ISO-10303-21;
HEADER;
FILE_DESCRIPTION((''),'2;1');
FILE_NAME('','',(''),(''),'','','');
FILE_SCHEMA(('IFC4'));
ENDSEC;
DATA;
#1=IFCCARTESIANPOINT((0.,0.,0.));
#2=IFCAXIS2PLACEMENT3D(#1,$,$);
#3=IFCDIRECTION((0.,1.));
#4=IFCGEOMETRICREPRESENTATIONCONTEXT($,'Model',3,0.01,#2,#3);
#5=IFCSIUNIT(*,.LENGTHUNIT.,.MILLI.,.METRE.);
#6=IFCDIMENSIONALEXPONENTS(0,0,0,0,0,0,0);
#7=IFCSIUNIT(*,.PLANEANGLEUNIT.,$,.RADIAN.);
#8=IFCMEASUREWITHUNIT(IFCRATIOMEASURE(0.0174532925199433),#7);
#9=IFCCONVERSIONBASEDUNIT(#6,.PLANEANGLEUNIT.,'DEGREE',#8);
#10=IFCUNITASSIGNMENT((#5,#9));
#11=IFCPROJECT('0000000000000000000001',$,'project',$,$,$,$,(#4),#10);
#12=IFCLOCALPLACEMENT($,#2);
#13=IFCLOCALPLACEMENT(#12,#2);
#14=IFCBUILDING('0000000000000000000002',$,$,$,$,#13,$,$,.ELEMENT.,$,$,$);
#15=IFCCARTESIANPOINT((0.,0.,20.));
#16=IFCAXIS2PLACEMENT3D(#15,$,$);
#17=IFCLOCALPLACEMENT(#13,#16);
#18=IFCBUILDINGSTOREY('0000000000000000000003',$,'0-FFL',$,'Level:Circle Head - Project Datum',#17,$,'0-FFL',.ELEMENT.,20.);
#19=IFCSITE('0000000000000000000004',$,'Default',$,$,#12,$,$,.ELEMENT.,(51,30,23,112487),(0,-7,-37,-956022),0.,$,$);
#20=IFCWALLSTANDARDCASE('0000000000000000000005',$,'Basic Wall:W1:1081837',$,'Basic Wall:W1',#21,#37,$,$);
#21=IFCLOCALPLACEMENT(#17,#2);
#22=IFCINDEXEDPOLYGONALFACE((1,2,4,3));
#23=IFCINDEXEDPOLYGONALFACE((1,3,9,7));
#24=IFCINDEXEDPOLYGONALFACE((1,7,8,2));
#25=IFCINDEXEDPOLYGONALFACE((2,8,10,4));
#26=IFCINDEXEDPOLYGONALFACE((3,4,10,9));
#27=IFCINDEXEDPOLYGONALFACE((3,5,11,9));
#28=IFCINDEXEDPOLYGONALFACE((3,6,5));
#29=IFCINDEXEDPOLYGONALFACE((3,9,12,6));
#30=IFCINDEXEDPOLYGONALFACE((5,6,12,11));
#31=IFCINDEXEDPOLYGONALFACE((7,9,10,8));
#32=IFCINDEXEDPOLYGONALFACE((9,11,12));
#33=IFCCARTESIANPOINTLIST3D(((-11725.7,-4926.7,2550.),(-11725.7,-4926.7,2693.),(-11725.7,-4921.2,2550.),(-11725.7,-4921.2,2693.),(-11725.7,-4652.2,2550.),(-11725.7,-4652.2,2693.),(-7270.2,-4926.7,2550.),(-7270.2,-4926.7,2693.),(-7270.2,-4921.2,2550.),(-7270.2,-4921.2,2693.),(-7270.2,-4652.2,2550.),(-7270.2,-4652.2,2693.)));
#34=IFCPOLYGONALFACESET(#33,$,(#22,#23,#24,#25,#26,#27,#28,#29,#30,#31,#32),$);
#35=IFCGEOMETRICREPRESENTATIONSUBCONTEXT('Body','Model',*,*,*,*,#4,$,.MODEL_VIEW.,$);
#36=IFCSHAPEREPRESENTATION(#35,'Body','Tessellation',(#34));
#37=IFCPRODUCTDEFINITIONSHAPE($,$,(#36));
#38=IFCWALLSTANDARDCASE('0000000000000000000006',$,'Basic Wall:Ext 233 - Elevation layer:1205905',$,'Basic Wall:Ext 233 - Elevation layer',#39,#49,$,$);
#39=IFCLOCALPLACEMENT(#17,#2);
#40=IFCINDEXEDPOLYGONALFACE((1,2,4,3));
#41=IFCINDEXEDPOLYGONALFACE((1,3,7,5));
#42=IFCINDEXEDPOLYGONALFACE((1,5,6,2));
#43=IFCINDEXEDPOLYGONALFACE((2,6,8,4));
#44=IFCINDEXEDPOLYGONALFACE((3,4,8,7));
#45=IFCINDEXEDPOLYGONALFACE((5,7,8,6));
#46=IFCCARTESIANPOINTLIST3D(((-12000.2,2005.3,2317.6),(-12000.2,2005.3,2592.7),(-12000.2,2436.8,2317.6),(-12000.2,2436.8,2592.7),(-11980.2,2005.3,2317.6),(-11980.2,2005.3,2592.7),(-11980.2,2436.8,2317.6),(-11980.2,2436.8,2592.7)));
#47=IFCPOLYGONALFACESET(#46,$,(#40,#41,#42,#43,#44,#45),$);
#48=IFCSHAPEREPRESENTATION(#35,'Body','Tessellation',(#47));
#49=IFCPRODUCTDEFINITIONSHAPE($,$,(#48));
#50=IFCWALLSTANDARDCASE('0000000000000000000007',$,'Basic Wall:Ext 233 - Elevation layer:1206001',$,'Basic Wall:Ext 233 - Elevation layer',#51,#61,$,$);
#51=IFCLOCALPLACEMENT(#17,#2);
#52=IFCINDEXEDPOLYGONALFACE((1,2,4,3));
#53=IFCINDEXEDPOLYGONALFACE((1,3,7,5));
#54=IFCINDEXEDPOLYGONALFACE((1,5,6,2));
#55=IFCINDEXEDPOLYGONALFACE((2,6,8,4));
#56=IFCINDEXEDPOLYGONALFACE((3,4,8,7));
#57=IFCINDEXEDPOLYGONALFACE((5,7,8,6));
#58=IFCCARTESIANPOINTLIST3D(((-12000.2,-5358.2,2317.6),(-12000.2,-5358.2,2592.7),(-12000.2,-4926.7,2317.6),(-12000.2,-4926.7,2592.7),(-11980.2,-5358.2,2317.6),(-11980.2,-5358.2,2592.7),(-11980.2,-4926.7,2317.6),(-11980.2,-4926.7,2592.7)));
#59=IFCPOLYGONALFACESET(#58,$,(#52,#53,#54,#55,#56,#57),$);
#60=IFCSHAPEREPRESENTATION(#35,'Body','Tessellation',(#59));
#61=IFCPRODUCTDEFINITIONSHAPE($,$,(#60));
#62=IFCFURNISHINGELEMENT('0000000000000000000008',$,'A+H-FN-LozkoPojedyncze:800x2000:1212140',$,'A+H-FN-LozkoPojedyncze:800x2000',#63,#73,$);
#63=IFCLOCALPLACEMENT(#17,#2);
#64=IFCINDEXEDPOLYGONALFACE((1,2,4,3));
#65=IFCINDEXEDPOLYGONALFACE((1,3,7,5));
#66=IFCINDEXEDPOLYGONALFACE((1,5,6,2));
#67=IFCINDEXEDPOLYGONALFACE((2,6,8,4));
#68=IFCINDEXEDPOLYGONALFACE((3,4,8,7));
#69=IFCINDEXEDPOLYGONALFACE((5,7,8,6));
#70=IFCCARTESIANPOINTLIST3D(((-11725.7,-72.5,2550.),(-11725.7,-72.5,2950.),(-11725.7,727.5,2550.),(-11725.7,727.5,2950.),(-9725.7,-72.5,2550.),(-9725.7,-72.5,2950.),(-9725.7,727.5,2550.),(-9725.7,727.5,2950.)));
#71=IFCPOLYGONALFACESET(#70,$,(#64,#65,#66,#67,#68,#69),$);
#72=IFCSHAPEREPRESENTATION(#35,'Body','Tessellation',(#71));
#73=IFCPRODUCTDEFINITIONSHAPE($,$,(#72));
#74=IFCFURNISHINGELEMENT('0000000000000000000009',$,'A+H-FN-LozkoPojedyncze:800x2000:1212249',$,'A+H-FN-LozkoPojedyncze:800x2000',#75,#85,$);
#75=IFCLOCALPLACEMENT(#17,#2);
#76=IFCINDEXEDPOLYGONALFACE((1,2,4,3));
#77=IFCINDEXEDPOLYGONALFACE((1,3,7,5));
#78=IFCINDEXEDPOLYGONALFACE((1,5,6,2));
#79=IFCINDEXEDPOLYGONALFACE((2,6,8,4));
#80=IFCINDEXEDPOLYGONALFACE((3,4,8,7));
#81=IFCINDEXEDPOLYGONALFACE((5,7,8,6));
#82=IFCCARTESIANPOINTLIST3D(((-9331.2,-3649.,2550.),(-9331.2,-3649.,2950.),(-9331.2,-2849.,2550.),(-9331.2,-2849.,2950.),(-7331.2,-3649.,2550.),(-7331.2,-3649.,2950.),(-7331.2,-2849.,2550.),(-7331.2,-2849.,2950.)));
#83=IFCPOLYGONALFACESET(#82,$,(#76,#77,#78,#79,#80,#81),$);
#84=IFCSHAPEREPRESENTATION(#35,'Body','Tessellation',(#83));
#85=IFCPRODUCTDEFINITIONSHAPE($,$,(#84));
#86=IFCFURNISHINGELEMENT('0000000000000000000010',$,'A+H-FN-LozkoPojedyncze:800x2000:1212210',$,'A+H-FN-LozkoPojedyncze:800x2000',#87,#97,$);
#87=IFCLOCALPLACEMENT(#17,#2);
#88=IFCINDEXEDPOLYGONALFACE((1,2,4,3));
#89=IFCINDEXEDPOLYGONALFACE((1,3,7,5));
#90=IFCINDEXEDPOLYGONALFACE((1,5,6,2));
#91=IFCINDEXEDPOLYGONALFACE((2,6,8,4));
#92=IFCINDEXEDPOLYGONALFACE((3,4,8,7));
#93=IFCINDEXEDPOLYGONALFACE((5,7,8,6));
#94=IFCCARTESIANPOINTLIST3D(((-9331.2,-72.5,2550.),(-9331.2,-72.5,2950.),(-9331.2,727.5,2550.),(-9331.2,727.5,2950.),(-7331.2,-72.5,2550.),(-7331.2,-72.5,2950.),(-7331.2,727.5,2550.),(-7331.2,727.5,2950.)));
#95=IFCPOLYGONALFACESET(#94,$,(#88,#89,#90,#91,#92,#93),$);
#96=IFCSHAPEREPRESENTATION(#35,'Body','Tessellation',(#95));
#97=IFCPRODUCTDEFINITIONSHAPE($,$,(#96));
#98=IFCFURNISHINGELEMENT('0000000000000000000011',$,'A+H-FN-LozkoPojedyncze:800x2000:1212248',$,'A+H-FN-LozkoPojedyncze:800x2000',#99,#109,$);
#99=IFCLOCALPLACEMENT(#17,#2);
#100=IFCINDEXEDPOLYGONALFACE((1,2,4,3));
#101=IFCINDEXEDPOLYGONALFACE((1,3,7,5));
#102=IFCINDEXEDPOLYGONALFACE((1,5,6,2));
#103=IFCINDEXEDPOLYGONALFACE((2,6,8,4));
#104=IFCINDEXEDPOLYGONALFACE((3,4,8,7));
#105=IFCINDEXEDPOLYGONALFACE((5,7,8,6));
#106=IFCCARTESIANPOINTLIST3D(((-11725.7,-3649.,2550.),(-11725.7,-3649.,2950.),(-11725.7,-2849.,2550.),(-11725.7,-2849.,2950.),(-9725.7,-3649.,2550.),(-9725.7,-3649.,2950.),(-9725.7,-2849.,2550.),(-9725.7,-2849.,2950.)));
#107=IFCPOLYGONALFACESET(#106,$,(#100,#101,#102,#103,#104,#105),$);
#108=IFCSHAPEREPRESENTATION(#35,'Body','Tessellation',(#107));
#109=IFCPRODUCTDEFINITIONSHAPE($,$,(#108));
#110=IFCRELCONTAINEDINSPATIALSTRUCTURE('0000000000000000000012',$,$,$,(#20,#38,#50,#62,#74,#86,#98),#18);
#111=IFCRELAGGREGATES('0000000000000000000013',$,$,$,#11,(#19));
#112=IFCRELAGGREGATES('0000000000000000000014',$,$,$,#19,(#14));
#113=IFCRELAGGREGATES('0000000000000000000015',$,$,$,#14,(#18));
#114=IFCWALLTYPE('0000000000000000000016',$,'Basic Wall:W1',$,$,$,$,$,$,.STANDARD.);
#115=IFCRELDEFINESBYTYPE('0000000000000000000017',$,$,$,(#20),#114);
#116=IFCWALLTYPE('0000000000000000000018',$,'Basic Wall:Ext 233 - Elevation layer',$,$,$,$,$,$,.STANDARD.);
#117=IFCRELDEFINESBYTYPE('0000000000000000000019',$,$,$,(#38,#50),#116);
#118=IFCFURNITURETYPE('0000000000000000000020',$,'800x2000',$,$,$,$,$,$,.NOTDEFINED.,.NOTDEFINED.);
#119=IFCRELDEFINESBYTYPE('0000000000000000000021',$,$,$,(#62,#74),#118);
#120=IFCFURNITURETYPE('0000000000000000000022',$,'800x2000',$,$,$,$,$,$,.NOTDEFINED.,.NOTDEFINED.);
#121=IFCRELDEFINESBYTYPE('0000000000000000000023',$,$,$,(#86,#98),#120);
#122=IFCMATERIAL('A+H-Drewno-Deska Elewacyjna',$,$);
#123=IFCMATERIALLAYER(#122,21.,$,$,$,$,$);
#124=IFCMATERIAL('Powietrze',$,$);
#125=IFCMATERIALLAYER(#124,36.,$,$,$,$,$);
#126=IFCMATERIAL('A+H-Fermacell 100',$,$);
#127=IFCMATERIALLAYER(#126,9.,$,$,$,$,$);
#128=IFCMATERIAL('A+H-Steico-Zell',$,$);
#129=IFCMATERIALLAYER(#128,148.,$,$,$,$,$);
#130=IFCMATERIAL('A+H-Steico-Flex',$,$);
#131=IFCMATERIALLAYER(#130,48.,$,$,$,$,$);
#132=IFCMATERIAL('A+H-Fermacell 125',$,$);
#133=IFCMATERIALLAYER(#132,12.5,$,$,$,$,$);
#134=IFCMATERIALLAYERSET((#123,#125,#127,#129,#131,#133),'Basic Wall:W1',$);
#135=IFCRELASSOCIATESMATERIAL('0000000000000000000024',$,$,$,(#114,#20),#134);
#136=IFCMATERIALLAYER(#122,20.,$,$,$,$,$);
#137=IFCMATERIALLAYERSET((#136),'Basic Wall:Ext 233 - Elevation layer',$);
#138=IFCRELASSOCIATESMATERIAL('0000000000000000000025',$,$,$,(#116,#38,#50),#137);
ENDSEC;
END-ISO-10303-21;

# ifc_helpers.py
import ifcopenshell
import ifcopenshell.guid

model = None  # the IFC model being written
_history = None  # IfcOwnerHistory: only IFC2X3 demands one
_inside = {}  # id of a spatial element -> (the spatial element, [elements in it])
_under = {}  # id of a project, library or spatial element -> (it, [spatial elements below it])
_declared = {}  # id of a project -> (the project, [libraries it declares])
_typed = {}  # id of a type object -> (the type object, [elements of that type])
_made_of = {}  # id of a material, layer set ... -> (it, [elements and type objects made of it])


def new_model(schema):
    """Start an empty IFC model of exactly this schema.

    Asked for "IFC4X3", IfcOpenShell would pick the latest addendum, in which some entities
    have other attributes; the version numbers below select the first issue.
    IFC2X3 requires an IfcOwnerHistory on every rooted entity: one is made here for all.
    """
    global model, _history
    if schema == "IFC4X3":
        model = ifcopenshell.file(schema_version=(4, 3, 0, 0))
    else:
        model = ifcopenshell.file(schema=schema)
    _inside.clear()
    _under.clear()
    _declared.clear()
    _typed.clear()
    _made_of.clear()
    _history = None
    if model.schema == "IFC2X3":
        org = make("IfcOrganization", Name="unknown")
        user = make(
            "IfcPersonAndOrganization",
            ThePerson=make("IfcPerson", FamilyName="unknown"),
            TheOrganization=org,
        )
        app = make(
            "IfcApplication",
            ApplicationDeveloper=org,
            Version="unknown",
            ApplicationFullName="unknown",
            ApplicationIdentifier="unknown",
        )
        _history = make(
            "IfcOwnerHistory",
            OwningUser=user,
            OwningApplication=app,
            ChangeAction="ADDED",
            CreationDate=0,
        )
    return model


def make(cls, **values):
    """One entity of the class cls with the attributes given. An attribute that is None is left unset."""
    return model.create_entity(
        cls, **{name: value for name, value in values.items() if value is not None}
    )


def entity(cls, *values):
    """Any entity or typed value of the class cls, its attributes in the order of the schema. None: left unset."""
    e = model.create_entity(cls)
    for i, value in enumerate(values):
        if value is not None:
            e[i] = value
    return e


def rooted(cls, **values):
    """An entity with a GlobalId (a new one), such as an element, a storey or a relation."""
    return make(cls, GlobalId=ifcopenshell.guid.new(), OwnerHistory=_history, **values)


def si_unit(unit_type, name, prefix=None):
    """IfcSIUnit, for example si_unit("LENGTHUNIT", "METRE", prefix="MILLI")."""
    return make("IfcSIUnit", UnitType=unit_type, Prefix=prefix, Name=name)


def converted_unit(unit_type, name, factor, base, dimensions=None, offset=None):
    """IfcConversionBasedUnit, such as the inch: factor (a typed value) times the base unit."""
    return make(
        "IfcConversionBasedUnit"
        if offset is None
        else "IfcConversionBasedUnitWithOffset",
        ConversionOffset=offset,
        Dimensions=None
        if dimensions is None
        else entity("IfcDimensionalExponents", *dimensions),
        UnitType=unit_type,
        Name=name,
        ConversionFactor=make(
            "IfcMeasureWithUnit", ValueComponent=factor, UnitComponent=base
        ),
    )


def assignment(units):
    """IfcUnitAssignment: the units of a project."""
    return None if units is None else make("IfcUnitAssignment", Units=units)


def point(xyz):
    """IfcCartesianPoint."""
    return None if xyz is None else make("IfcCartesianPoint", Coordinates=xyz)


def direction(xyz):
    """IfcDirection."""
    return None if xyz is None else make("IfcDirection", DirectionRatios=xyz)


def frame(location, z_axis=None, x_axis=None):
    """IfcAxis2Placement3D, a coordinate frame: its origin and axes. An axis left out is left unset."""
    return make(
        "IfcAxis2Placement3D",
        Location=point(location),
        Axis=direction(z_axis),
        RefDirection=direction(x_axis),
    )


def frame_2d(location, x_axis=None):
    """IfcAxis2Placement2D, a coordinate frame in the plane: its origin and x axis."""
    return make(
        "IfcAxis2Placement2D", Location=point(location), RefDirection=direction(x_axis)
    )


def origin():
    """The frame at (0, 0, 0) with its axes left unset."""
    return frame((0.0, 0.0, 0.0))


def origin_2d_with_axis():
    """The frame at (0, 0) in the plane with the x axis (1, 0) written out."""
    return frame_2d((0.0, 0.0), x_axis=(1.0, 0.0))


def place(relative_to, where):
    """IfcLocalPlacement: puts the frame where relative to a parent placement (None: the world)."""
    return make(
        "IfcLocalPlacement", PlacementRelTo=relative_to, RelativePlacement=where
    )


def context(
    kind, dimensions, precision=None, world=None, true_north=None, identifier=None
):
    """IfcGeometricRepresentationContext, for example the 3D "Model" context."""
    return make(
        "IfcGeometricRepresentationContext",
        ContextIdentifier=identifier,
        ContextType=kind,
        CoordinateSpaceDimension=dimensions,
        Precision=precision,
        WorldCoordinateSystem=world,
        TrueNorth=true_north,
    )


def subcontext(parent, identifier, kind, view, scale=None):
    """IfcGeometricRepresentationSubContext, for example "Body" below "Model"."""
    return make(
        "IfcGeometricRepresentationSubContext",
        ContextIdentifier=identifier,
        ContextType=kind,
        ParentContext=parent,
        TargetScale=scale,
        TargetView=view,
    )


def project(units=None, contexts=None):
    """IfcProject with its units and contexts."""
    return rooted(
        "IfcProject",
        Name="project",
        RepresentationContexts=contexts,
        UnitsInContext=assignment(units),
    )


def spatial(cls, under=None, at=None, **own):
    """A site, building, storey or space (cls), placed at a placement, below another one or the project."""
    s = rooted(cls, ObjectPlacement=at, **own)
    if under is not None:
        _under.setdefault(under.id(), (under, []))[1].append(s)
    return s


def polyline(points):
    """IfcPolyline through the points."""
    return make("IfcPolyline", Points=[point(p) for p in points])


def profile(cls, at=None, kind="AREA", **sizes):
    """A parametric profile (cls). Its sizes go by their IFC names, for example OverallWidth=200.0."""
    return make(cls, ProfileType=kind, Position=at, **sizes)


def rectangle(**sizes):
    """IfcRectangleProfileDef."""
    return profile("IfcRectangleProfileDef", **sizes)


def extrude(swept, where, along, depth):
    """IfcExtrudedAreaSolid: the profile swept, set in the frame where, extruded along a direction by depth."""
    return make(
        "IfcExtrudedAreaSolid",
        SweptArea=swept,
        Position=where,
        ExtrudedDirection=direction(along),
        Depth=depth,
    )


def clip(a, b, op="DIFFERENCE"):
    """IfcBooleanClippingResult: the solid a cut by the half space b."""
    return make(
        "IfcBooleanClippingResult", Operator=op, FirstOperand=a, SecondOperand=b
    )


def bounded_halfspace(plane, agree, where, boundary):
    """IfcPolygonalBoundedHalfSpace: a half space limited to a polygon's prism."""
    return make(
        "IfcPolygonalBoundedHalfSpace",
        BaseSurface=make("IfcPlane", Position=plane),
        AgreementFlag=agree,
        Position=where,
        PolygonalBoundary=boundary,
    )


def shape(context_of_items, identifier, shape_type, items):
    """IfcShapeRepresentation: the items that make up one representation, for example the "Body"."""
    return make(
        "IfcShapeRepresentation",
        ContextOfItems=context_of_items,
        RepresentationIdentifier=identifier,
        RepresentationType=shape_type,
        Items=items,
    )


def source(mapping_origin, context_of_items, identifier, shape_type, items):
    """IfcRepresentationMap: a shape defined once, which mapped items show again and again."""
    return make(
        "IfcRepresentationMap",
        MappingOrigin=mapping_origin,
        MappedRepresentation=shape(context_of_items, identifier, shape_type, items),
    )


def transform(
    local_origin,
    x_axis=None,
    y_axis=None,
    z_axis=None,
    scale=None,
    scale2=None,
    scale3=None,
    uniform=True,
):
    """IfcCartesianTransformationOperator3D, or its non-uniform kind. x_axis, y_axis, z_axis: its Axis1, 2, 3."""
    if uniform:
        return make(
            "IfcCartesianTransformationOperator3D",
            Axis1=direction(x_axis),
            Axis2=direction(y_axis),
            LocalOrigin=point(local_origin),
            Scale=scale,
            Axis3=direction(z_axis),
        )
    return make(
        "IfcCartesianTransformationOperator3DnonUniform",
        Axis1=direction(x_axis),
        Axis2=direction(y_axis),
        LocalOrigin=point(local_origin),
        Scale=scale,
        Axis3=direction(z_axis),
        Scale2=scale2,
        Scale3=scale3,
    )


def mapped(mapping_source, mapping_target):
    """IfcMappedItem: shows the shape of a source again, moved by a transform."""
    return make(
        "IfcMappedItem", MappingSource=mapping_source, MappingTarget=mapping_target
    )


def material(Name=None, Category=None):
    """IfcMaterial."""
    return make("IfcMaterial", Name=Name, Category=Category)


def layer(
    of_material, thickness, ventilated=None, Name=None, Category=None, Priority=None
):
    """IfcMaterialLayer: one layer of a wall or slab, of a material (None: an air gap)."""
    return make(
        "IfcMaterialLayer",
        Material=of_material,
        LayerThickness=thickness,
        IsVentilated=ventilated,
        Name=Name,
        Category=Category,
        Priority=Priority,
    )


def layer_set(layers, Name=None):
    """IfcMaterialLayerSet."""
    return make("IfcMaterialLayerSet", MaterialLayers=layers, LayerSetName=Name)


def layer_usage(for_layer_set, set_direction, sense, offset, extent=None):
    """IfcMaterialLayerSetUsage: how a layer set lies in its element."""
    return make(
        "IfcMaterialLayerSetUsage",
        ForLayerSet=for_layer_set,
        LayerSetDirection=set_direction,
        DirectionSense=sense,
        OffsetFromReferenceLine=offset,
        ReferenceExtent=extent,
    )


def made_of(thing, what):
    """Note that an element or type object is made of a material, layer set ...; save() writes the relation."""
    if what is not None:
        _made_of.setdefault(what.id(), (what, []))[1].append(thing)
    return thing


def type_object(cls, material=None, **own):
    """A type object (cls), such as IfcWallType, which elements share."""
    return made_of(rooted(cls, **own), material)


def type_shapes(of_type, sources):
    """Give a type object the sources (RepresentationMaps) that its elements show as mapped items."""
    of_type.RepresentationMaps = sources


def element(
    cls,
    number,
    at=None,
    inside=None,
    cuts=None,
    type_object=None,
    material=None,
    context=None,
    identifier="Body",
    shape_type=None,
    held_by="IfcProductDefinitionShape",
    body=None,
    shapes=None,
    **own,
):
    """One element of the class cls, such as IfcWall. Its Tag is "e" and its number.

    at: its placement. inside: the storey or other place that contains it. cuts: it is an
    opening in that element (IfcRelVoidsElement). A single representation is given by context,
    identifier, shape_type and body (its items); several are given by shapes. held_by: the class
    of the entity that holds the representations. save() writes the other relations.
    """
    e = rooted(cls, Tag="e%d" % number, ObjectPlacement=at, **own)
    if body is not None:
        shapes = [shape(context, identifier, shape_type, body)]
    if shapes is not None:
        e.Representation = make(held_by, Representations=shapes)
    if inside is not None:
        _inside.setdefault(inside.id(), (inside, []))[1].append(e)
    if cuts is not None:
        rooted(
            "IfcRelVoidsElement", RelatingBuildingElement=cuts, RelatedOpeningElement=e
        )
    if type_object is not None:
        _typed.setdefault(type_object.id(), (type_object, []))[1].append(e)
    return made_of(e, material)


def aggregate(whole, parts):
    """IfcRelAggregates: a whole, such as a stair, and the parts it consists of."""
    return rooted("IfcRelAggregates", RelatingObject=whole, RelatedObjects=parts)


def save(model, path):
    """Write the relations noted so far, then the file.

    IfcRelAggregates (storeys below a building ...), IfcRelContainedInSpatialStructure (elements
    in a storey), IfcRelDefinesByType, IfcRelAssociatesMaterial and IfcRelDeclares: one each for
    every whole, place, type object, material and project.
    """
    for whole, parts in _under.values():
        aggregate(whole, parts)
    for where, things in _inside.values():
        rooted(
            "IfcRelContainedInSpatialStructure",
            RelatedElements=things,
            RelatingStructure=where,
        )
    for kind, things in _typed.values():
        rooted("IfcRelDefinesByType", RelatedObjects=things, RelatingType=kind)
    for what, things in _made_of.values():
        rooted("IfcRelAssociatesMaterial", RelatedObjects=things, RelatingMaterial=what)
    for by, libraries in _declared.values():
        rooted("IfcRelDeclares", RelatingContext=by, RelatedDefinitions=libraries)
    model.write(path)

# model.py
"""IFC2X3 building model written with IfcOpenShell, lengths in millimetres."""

from ifc_helpers import new_model, entity, si_unit, converted_unit, direction, frame, frame_2d, origin, origin_2d_with_axis, place, context, subcontext, project, spatial, polyline, rectangle, extrude, clip, bounded_halfspace, source, transform, mapped, material, layer, layer_set, layer_usage, type_object, type_shapes, element, save


model = new_model("IFC2X3")

# Units and contexts
model_context = context("Model", 3, precision=0.01, world=origin(), true_north=direction((0.0, 1.0)))
body_context = subcontext(model_context, "Body", "Model", "MODEL_VIEW")
ifc_project = project(units=[si_unit("LENGTHUNIT", "METRE", prefix="MILLI"), converted_unit("PLANEANGLEUNIT", "DEGREE", entity("IfcRatioMeasure", 0.0174532925199433), si_unit("PLANEANGLEUNIT", "RADIAN"), dimensions=[0, 0, 0, 0, 0, 0, 0])], contexts=[model_context])

# Site, building, storey
site_placement = place(None, origin())
site = spatial("IfcSite", under=ifc_project, at=site_placement, Name="Default", CompositionType="ELEMENT", RefLatitude=(51, 30, 23, 112487), RefLongitude=(0, -7, -37, -956022), RefElevation=0.0)
building_placement = place(site_placement, origin())
building = spatial("IfcBuilding", under=site, at=building_placement, CompositionType="ELEMENT")
storey_placement = place(building_placement, frame((0.0, 0.0, 20.0)))
storey = spatial("IfcBuildingStorey", under=building, at=storey_placement, Name="0-FFL", ObjectType="Level:Circle Head - Project Datum", LongName="0-FFL", CompositionType="ELEMENT", Elevation=20.0)

# Shared definitions
ifc_material_1 = material(Name="A+H-Steico-Zell")
ifc_material_2 = material(Name="A+H-Fermacell 100")

# Walls
ifc_material_3 = material(Name="A+H-Drewno-Deska Elewacyjna")
ifc_layer_1 = layer(ifc_material_3, 21.0)
ifc_material_4 = material(Name="Powietrze")
ifc_layer_2 = layer(ifc_material_4, 36.0)
ifc_layer_3 = layer(ifc_material_2, 9.0)
ifc_layer_4 = layer(ifc_material_1, 148.0)
ifc_material_5 = material(Name="A+H-Steico-Flex")
ifc_layer_5 = layer(ifc_material_5, 48.0)
ifc_material_6 = material(Name="A+H-Fermacell 125")
ifc_layer_6 = layer(ifc_material_6, 12.5)
ifc_layer_set_1 = layer_set([ifc_layer_1, ifc_layer_2, ifc_layer_3, ifc_layer_4, ifc_layer_5, ifc_layer_6], Name="Basic Wall:W1")
ifc_layer_usage_1 = layer_usage(ifc_layer_set_1, "AXIS2", "POSITIVE", -137.2)
wall_type_1 = type_object("IfcWallType", Name="Basic Wall:W1", PredefinedType="STANDARD", material=ifc_layer_set_1)
wall_1_placement = place(storey_placement, frame((-11725.7, -4789.5, 2550.0)))
element("IfcWallStandardCase", 1, at=wall_1_placement, inside=storey, type_object=wall_type_1, material=ifc_layer_usage_1, Name="Basic Wall:W1:1081837", ObjectType="Basic Wall:W1", context=body_context, shape_type="Clipping", body=[
    clip(extrude(rectangle(XDim=4455.5, YDim=274.5, at=frame_2d((2227.8, 0.0), x_axis=(-1.0, 0.0))), origin(), (0.0, 0.0, 1.0), 143.0), bounded_halfspace(frame((4455.5, 137.3, 143.0), z_axis=(0.0, -0.469472, 0.882948), x_axis=(1.0, 0.0, 0.0)), False, frame((4455.5, 137.3, 143.0)), polyline([(0.0, 0.0), (-61.0, 0.0), (-4455.5, 0.0), (-4455.5, -269.0), (0.0, -269.0), (0.0, 0.0)]))),
])
ifc_layer_7 = layer(ifc_material_3, 20.0)
ifc_layer_set_2 = layer_set([ifc_layer_7], Name="Basic Wall:Ext 233 - Elevation layer")
ifc_layer_usage_2 = layer_usage(ifc_layer_set_2, "AXIS2", "NEGATIVE", 10.0)
wall_type_2 = type_object("IfcWallType", Name="Basic Wall:Ext 233 - Elevation layer", PredefinedType="STANDARD", material=ifc_layer_set_2)
wall_2_placement = place(storey_placement, frame((-11990.2, 2005.3, 2317.6), z_axis=(0.0, 0.0, 1.0), x_axis=(0.0, 1.0, 0.0)))
element("IfcWallStandardCase", 2, at=wall_2_placement, inside=storey, type_object=wall_type_2, material=ifc_layer_usage_2, Name="Basic Wall:Ext 233 - Elevation layer:1205905", ObjectType="Basic Wall:Ext 233 - Elevation layer", context=body_context, shape_type="SweptSolid", body=[
    extrude(rectangle(XDim=431.5, YDim=20.0, at=frame_2d((215.7, 0.0), x_axis=(-1.0, 0.0))), origin(), (0.0, 0.0, 1.0), 275.1),
])
ifc_layer_usage_3 = layer_usage(ifc_layer_set_2, "AXIS2", "POSITIVE", -10.0)
wall_3_placement = place(storey_placement, frame((-11990.2, -4926.7, 2317.6), z_axis=(0.0, 0.0, 1.0), x_axis=(0.0, -1.0, 0.0)))
element("IfcWallStandardCase", 3, at=wall_3_placement, inside=storey, type_object=wall_type_2, material=ifc_layer_usage_3, Name="Basic Wall:Ext 233 - Elevation layer:1206001", ObjectType="Basic Wall:Ext 233 - Elevation layer", context=body_context, shape_type="SweptSolid", body=[
    extrude(rectangle(XDim=431.5, YDim=20.0, at=frame_2d((215.7, 0.0), x_axis=(-1.0, 0.0))), origin(), (0.0, 0.0, 1.0), 275.1),
])

# Furnishing elements
furniture_type_1 = type_object("IfcFurnitureType", Name="800x2000")
shared_shape_1 = source(origin(), body_context, "Body", "SweptSolid", [
    extrude(rectangle(XDim=800.0, YDim=2000.0, at=origin_2d_with_axis()), frame((0.0, 0.0, 0.0), z_axis=(0.0, 0.0, 1.0), x_axis=(-1.0, 0.0, 0.0)), (0.0, 0.0, 1.0), 400.0),
])
type_shapes(furniture_type_1, [shared_shape_1])
for number, where, z_axis, x_axis, name in (
    (4, (-10725.7, 327.5, 2550.0), (0.0, 0.0, 1.0), (0.0, 1.0, 0.0), "A+H-FN-LozkoPojedyncze:800x2000:1212140"),
    (5, (-8331.2, -3249.0, 2550.0), (0.0, 0.0, 1.0), (0.0, -1.0, 0.0), "A+H-FN-LozkoPojedyncze:800x2000:1212249"),
):
    element("IfcFurnishingElement", number, at=place(storey_placement, frame(where, z_axis=z_axis, x_axis=x_axis)), inside=storey, type_object=furniture_type_1, Name=name, ObjectType="A+H-FN-LozkoPojedyncze:800x2000", context=body_context, shape_type="MappedRepresentation", body=[
        mapped(shared_shape_1, transform((0.0, 0.0, 0.0), scale=1.0)),
    ])
furniture_type_2 = type_object("IfcFurnitureType", Name="800x2000")
shared_shape_2 = source(origin(), body_context, "Body", "SweptSolid", [
    extrude(rectangle(XDim=2000.0, YDim=800.0, at=origin_2d_with_axis()), frame((0.0, 0.0, 0.0), z_axis=(0.0, 0.0, 1.0), x_axis=(0.0, 1.0, 0.0)), (0.0, 0.0, 1.0), 400.0),
])
type_shapes(furniture_type_2, [shared_shape_2])
for number, where, z_axis, x_axis, name in (
    (6, (-8331.2, 327.5, 2550.0), (0.0, 0.0, 1.0), (0.0, 1.0, 0.0), "A+H-FN-LozkoPojedyncze:800x2000:1212210"),
    (7, (-10725.7, -3249.0, 2550.0), (0.0, 0.0, 1.0), (0.0, -1.0, 0.0), "A+H-FN-LozkoPojedyncze:800x2000:1212248"),
):
    element("IfcFurnishingElement", number, at=place(storey_placement, frame(where, z_axis=z_axis, x_axis=x_axis)), inside=storey, type_object=furniture_type_2, Name=name, ObjectType="A+H-FN-LozkoPojedyncze:800x2000", context=body_context, shape_type="MappedRepresentation", body=[
        mapped(shared_shape_2, transform((0.0, 0.0, 0.0), scale=1.0)),
    ])

save(model, "model.ifc")
